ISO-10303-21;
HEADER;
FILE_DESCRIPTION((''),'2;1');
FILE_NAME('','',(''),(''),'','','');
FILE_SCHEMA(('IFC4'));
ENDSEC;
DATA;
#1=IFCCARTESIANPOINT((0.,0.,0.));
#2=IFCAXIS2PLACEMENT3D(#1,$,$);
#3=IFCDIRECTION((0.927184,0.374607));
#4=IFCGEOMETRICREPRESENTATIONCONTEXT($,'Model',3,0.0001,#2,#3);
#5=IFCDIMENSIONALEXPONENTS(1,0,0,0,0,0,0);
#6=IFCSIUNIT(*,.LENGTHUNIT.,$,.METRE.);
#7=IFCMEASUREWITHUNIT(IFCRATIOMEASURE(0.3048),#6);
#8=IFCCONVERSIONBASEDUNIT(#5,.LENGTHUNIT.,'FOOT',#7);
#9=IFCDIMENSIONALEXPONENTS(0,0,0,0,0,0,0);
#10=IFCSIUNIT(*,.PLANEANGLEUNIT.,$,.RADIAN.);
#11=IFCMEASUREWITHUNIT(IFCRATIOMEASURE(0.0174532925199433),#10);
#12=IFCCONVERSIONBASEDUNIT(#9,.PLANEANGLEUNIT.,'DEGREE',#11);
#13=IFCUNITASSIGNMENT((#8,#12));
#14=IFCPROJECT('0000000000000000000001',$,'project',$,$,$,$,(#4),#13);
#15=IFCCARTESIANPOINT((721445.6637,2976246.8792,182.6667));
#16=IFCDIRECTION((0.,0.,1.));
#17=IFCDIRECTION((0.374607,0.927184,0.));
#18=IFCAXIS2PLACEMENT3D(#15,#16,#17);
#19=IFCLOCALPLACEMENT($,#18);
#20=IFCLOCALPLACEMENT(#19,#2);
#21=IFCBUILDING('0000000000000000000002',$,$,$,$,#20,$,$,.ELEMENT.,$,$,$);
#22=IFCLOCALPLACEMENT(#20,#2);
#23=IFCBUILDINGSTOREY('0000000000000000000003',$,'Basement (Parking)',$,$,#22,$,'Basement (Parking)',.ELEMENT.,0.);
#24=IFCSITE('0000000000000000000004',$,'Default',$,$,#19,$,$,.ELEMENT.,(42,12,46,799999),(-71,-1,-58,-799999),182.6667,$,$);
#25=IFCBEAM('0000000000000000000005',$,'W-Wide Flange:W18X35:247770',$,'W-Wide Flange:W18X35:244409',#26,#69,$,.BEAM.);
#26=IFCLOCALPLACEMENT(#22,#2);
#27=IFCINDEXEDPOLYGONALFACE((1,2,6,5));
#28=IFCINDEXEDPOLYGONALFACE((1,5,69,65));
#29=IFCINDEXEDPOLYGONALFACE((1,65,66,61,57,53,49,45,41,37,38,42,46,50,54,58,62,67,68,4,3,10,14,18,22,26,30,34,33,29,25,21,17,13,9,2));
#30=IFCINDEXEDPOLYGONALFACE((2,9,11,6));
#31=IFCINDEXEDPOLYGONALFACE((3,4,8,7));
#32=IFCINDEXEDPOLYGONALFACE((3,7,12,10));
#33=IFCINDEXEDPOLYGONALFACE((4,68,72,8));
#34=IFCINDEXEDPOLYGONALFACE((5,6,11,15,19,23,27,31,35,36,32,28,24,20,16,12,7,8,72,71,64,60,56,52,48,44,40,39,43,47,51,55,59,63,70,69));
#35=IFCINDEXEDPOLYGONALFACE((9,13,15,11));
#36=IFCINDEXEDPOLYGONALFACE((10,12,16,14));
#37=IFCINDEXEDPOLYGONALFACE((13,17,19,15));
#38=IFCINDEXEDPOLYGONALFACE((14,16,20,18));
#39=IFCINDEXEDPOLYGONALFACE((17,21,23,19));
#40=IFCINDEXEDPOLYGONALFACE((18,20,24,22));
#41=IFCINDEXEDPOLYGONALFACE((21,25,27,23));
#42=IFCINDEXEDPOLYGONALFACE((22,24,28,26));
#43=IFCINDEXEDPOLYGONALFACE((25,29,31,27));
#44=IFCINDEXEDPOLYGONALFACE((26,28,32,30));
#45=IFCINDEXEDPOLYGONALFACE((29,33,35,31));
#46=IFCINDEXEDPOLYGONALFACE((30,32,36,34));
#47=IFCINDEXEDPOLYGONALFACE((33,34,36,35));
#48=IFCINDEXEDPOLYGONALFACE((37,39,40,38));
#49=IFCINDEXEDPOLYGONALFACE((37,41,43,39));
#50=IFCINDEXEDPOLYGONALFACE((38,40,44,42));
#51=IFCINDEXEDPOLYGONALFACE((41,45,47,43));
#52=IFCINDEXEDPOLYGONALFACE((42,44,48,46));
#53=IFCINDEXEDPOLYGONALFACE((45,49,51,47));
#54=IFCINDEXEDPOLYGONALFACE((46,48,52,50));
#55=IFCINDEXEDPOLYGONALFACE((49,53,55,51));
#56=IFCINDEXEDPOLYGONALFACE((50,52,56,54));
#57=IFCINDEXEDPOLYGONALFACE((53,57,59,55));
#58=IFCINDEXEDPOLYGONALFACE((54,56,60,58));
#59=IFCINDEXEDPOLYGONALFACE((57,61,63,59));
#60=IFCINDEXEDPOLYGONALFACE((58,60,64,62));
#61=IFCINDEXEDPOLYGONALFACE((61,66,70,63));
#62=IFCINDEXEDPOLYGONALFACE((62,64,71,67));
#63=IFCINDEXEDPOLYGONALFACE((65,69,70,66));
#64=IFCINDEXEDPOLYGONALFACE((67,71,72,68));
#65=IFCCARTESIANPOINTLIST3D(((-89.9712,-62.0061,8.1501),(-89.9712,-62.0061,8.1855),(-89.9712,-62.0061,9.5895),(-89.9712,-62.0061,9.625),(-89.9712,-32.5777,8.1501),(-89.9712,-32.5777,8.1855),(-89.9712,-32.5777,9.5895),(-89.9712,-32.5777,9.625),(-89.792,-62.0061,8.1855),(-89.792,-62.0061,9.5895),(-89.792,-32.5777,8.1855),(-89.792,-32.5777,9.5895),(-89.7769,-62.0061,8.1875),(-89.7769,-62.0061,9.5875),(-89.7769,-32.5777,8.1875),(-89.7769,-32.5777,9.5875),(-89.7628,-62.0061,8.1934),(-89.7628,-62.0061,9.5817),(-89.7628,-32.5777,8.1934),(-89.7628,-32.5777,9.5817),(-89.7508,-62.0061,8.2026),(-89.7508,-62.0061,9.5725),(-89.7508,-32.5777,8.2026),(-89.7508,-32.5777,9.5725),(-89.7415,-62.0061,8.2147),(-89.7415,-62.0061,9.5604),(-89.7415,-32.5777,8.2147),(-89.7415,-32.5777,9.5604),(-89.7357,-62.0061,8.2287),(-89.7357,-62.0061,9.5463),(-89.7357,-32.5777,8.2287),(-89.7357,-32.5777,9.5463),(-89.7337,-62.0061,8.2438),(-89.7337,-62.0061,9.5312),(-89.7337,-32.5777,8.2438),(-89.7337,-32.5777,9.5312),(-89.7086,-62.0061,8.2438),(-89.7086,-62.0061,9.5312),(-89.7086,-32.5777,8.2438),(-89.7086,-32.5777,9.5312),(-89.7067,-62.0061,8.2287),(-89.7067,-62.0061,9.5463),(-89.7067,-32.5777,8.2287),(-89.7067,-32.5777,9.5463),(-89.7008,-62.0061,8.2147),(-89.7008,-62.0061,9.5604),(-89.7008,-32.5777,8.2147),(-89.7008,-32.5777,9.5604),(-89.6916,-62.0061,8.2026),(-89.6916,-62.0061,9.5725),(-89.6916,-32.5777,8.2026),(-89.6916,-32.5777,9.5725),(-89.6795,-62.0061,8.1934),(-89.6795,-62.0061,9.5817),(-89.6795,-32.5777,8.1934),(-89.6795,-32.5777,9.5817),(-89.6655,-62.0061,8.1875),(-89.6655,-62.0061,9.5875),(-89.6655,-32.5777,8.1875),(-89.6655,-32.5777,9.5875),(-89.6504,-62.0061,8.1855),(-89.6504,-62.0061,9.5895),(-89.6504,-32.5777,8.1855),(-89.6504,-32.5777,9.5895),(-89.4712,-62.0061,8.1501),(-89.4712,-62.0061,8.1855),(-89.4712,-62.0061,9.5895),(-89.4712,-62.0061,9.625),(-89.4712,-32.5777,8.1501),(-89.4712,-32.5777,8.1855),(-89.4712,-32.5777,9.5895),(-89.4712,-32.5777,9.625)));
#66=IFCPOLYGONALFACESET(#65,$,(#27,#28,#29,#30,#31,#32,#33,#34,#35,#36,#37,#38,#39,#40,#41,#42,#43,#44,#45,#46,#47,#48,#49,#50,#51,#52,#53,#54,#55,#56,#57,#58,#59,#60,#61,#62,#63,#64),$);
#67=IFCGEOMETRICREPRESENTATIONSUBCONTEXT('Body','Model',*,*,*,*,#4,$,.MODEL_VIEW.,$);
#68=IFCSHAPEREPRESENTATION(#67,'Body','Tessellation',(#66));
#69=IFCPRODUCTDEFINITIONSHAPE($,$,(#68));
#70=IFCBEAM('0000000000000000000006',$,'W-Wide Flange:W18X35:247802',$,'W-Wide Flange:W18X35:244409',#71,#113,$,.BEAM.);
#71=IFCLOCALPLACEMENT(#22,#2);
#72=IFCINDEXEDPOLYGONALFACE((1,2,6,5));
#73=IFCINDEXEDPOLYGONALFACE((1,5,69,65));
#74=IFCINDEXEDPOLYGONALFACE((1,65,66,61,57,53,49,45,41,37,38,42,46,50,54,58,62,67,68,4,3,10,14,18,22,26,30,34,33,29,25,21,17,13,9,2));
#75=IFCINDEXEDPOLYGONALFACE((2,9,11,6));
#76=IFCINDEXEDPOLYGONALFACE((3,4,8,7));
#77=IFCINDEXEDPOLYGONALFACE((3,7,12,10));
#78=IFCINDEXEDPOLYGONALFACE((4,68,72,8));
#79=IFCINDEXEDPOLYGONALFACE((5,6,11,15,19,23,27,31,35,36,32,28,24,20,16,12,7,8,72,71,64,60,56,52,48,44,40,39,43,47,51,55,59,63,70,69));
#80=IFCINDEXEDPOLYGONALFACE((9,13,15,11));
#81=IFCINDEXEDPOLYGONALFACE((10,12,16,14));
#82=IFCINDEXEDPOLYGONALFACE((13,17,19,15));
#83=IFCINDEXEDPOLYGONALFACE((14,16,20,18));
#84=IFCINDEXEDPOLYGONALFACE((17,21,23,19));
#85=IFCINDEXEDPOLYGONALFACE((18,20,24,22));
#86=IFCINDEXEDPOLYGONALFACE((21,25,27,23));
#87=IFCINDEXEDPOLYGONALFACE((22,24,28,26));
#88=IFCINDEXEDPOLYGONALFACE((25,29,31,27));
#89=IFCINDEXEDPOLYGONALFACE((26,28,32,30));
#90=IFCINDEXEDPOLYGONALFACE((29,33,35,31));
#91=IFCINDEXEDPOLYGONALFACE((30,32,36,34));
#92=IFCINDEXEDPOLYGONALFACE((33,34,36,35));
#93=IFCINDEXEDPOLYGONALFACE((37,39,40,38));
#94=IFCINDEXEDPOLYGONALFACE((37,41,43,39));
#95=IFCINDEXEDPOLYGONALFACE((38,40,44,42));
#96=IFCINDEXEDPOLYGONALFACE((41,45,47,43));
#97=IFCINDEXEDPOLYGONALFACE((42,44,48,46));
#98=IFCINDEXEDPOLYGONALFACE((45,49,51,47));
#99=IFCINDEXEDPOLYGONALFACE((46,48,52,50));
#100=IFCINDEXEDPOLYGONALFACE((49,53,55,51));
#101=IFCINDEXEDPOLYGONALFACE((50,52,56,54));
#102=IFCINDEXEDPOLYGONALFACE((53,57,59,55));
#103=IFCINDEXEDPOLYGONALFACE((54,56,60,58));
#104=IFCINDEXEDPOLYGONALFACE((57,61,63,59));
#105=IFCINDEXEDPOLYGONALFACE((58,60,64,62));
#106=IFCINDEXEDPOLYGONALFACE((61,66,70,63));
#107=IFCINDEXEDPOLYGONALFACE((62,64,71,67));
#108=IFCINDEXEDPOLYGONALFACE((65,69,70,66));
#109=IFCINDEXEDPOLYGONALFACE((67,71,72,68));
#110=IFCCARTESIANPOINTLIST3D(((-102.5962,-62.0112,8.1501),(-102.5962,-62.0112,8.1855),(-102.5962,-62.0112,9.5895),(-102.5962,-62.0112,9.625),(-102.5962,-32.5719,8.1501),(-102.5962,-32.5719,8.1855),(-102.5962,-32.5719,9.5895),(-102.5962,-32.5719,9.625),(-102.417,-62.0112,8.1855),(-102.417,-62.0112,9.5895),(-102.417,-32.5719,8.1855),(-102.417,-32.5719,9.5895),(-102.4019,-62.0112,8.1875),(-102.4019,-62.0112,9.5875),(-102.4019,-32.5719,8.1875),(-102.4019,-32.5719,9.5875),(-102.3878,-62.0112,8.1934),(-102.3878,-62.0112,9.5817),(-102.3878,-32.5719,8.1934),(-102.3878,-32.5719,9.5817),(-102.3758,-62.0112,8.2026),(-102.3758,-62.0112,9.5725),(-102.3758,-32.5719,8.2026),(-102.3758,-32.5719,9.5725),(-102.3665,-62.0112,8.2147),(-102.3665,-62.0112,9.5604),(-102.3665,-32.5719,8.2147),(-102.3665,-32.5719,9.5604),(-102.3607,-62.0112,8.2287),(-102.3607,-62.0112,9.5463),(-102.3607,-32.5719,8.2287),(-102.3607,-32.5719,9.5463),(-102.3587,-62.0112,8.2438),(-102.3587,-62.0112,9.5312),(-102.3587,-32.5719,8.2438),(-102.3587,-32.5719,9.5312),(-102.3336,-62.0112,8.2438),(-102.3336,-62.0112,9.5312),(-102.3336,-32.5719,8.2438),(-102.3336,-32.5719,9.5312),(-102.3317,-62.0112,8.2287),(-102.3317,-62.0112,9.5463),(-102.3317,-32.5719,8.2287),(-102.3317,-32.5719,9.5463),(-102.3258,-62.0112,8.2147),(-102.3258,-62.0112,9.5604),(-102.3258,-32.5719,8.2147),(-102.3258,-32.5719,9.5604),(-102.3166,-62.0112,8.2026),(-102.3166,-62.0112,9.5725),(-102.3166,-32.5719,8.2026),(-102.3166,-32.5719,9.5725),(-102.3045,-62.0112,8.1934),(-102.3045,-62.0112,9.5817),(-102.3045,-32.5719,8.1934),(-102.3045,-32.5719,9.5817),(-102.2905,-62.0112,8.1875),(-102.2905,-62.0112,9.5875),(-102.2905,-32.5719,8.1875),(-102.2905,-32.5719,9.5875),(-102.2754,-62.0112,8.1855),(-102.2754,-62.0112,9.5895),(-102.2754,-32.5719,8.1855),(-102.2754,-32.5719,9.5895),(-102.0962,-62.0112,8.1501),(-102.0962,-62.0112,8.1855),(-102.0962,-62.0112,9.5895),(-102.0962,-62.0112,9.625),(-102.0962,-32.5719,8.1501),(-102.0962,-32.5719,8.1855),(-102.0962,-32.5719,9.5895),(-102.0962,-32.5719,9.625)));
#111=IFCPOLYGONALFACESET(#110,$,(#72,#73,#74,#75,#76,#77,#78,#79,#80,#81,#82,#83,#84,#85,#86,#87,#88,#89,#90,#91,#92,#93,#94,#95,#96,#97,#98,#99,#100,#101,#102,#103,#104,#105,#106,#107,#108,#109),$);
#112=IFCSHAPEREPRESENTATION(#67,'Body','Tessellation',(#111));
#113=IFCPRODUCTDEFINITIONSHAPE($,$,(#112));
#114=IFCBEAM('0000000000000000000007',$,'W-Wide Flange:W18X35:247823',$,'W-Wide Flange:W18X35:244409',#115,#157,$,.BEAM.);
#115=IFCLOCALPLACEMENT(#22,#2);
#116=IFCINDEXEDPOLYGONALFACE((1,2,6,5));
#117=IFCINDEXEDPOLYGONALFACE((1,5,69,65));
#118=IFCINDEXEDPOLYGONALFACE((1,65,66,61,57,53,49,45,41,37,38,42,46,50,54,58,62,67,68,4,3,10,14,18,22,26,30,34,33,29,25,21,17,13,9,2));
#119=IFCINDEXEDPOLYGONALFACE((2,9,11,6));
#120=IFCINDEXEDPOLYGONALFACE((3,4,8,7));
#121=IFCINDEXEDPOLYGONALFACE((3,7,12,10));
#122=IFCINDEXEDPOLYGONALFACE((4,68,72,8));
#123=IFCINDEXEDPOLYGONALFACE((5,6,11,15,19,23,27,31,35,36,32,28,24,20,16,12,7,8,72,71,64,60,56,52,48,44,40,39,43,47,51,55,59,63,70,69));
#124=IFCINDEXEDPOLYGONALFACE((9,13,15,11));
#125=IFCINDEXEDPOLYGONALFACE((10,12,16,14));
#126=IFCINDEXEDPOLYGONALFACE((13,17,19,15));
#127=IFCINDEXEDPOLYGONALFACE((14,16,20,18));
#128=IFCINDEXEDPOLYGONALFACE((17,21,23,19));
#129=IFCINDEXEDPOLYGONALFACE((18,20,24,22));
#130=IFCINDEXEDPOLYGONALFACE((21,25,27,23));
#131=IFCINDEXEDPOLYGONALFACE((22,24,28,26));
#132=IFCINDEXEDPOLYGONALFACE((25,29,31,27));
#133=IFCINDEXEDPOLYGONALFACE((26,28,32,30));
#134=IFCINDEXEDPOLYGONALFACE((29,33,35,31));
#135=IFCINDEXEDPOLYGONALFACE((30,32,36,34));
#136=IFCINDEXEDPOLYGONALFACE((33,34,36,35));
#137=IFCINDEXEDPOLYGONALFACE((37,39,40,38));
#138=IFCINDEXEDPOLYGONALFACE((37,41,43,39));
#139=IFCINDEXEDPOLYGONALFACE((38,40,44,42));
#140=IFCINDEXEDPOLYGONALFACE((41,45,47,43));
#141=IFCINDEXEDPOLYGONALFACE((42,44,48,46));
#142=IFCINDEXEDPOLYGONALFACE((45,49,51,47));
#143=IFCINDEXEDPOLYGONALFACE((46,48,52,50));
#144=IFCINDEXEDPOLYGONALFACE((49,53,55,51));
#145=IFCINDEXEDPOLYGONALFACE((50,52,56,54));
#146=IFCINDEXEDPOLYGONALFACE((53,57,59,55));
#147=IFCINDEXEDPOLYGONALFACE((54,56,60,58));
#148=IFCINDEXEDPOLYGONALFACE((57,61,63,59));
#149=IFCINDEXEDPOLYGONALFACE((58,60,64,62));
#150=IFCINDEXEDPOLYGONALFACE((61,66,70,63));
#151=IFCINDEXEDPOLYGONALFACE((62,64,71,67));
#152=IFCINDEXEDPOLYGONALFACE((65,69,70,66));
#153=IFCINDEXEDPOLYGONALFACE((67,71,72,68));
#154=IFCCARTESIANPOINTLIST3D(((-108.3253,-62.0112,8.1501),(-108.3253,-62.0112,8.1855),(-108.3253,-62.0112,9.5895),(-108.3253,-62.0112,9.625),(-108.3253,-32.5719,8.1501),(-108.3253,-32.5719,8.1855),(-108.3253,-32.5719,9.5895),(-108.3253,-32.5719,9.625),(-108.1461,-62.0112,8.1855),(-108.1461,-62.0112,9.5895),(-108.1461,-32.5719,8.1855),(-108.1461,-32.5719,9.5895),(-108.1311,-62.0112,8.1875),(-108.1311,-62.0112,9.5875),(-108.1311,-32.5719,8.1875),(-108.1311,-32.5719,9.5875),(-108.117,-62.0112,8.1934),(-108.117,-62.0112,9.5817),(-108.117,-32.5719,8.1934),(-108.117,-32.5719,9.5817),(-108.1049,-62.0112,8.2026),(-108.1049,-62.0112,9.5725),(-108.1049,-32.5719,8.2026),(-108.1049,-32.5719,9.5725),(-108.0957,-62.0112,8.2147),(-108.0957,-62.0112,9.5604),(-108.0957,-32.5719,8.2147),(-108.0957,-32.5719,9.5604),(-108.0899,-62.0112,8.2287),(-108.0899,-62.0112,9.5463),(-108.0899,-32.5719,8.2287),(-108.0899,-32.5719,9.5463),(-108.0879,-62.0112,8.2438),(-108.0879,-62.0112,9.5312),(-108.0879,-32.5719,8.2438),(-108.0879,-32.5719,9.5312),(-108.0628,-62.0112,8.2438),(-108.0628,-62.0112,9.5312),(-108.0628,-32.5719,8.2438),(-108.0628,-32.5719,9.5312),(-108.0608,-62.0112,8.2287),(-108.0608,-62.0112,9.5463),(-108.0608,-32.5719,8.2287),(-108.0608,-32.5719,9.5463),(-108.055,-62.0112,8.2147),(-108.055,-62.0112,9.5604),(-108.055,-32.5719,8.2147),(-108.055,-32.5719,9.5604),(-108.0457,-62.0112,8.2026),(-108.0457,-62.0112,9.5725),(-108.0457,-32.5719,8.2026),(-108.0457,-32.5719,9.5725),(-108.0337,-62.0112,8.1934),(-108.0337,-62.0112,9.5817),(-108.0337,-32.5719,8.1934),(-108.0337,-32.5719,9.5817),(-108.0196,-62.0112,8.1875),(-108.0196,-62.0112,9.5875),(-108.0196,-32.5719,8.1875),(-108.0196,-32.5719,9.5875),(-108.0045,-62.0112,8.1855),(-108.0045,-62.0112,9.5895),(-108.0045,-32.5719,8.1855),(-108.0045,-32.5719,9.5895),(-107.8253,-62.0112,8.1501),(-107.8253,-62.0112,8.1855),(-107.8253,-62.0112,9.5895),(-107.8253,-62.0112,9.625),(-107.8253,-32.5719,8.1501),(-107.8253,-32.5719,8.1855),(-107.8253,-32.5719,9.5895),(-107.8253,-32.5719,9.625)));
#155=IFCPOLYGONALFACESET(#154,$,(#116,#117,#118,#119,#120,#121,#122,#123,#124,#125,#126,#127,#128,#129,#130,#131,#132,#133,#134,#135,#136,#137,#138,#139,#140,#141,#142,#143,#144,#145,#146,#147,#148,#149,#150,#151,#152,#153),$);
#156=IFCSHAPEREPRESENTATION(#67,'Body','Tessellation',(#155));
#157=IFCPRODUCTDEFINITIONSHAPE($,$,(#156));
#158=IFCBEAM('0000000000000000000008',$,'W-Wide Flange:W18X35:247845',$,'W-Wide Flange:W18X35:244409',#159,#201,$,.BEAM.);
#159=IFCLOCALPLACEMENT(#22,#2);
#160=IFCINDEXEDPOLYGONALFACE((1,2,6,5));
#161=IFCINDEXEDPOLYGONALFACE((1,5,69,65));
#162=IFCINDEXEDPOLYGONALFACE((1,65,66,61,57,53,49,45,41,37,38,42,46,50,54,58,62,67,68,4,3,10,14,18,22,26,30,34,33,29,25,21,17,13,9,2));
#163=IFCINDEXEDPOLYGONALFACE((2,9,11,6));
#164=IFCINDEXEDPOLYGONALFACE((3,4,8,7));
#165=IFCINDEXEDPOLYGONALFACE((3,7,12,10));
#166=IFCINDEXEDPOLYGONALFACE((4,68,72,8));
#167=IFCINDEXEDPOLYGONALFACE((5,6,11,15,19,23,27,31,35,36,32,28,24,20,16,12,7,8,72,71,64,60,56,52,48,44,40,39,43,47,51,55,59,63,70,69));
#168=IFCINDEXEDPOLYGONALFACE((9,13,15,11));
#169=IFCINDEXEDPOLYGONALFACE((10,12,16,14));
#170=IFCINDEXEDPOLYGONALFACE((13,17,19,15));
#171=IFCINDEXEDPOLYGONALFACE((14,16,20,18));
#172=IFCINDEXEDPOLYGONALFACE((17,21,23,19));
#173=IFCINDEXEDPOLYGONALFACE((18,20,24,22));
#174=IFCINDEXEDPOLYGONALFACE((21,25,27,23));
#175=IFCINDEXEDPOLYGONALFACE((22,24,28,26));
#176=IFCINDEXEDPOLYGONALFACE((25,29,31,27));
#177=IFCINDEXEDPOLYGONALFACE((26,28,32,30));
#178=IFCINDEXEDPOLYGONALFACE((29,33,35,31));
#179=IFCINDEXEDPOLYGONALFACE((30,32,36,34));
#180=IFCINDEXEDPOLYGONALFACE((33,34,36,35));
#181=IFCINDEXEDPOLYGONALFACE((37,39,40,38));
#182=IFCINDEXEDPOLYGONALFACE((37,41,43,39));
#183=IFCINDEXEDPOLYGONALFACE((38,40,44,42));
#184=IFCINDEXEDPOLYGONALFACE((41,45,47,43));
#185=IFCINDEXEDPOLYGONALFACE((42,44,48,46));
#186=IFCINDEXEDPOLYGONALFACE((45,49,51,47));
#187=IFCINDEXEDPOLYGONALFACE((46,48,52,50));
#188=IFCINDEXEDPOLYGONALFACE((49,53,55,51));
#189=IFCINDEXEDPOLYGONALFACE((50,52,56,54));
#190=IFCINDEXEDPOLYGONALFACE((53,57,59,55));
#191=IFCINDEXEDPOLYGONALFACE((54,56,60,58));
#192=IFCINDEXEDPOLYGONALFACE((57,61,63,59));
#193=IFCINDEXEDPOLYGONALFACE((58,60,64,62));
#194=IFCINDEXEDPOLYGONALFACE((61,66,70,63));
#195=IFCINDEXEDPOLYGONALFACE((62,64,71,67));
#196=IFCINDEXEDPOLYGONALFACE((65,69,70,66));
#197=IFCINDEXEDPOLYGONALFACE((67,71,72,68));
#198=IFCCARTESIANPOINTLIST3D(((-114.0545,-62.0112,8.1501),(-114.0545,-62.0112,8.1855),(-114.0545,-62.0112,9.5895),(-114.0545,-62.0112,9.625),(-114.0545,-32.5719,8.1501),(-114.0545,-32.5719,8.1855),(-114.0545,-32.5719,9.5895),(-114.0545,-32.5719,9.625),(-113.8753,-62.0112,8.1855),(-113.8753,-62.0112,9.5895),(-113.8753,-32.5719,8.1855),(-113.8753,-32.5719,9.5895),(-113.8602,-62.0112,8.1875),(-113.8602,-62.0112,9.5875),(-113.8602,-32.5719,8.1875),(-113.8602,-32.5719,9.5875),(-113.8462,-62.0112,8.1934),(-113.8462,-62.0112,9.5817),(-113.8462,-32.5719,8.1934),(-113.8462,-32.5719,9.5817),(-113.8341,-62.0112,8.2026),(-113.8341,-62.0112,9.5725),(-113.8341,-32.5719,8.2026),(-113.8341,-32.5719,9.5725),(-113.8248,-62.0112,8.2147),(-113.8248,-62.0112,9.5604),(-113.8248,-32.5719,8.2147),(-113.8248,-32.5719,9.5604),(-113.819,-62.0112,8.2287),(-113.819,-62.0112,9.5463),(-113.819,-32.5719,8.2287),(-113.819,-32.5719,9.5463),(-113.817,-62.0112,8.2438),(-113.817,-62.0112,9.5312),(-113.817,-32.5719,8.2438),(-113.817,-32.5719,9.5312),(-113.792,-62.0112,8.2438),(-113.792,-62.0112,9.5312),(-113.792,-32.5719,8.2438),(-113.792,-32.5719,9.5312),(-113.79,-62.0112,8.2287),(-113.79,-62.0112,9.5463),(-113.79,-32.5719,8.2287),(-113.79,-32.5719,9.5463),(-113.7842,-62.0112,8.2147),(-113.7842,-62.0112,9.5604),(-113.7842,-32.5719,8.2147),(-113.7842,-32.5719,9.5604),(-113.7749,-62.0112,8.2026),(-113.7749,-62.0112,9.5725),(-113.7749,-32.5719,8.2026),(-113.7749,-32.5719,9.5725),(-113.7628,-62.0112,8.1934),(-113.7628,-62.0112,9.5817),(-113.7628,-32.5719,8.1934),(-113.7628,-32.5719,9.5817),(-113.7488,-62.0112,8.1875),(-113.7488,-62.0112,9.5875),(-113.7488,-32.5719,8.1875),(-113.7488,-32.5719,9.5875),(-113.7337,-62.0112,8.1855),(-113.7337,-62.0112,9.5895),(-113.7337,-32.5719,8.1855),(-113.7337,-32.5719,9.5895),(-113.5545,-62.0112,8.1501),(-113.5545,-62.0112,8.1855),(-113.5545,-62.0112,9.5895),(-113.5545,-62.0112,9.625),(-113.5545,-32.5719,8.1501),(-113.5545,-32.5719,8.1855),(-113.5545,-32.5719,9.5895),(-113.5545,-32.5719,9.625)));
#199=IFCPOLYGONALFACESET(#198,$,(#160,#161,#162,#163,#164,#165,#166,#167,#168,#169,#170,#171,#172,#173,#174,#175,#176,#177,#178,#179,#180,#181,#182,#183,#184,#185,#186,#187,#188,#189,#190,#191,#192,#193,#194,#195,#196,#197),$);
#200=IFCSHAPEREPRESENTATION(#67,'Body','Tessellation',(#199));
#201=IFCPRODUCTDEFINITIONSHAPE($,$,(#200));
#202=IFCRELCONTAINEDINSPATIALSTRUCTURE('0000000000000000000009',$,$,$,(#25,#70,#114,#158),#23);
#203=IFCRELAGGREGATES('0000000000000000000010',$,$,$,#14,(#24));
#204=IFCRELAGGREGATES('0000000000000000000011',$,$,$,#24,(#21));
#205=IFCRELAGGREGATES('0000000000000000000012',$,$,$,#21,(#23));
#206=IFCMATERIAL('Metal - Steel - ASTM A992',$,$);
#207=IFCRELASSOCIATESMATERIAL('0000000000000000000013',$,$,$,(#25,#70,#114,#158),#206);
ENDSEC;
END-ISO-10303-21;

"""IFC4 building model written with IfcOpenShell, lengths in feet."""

from ifc_helpers import new_model, entity, si_unit, converted_unit, direction, frame, frame_2d, origin, place, context, subcontext, project, spatial, i_section, extrude, material, element, save


model = new_model("IFC4")

# Units and contexts
model_context = context("Model", 3, precision=0.0001, world=origin(), true_north=direction((0.927184, 0.374607)))
body_context = subcontext(model_context, "Body", "Model", "MODEL_VIEW")
ifc_project = project(units=[converted_unit("LENGTHUNIT", "FOOT", entity("IfcRatioMeasure", 0.3048), si_unit("LENGTHUNIT", "METRE"), dimensions=[1, 0, 0, 0, 0, 0, 0]), converted_unit("PLANEANGLEUNIT", "DEGREE", entity("IfcRatioMeasure", 0.0174532925199433), si_unit("PLANEANGLEUNIT", "RADIAN"), dimensions=[0, 0, 0, 0, 0, 0, 0])], contexts=[model_context])

# Site, building, storey
site_placement = place(None, frame((721445.6637, 2976246.8792, 182.6667), z_axis=(0.0, 0.0, 1.0), x_axis=(0.374607, 0.927184, 0.0)))
site = spatial("IfcSite", under=ifc_project, at=site_placement, Name="Default", CompositionType="ELEMENT", RefLatitude=(42, 12, 46, 799999), RefLongitude=(-71, -1, -58, -799999), RefElevation=182.6667)
building_placement = place(site_placement, origin())
building = spatial("IfcBuilding", under=site, at=building_placement, CompositionType="ELEMENT")
storey_placement = place(building_placement, origin())
storey = spatial("IfcBuildingStorey", under=building, at=storey_placement, Name="Basement (Parking)", LongName="Basement (Parking)", CompositionType="ELEMENT", Elevation=0.0)

# Shared definitions
ifc_material_1 = material(Name="Metal - Steel - ASTM A992")

# Beams
beam_1_placement = place(storey_placement, frame((-89.7212, -62.3961, 9.625), z_axis=(0.0, 0.0, 1.0), x_axis=(0.0, 1.0, 0.0)))
element("IfcBeam", 1, at=beam_1_placement, inside=storey, material=ifc_material_1, Name="W-Wide Flange:W18X35:247770", ObjectType="W-Wide Flange:W18X35:244409", PredefinedType="BEAM", context=body_context, shape_type="SweptSolid", body=[
    extrude(i_section(OverallWidth=0.5, OverallDepth=1.4749, WebThickness=0.0251, FlangeThickness=0.0355, FilletRadius=0.0583, at=frame_2d((0.0, 0.0), x_axis=(0.0, 1.0))), frame((0.39, 0.0, -0.7375), z_axis=(1.0, 0.0, 0.0), x_axis=(0.0, 0.0, -1.0)), (0.0, 0.0, 1.0), 29.4284),
])
beam_2_placement = place(storey_placement, frame((-102.3462, -62.3961, 9.625), z_axis=(0.0, 0.0, 1.0), x_axis=(0.0, 1.0, 0.0)))
element("IfcBeam", 2, at=beam_2_placement, inside=storey, material=ifc_material_1, Name="W-Wide Flange:W18X35:247802", ObjectType="W-Wide Flange:W18X35:244409", PredefinedType="BEAM", context=body_context, shape_type="SweptSolid", body=[
    extrude(i_section(OverallWidth=0.5, OverallDepth=1.4749, WebThickness=0.0251, FlangeThickness=0.0355, FilletRadius=0.0583, at=frame_2d((0.0, 0.0), x_axis=(0.0, 1.0))), frame((0.3849, 0.0, -0.7375), z_axis=(1.0, 0.0, 0.0), x_axis=(0.0, 0.0, -1.0)), (0.0, 0.0, 1.0), 29.4393),
])
beam_3_placement = place(storey_placement, frame((-108.0753, -62.3961, 9.625), z_axis=(0.0, 0.0, 1.0), x_axis=(0.0, 1.0, 0.0)))
element("IfcBeam", 3, at=beam_3_placement, inside=storey, material=ifc_material_1, Name="W-Wide Flange:W18X35:247823", ObjectType="W-Wide Flange:W18X35:244409", PredefinedType="BEAM", context=body_context, shape_type="SweptSolid", body=[
    extrude(i_section(OverallWidth=0.5, OverallDepth=1.4749, WebThickness=0.0251, FlangeThickness=0.0355, FilletRadius=0.0583, at=frame_2d((0.0, 0.0), x_axis=(0.0, 1.0))), frame((0.3849, 0.0, -0.7375), z_axis=(1.0, 0.0, 0.0), x_axis=(0.0, 0.0, -1.0)), (0.0, 0.0, 1.0), 29.4393),
])
beam_4_placement = place(storey_placement, frame((-113.8045, -62.3961, 9.625), z_axis=(0.0, 0.0, 1.0), x_axis=(0.0, 1.0, 0.0)))
element("IfcBeam", 4, at=beam_4_placement, inside=storey, material=ifc_material_1, Name="W-Wide Flange:W18X35:247845", ObjectType="W-Wide Flange:W18X35:244409", PredefinedType="BEAM", context=body_context, shape_type="SweptSolid", body=[
    extrude(i_section(OverallWidth=0.5, OverallDepth=1.4749, WebThickness=0.0251, FlangeThickness=0.0355, FilletRadius=0.0583, at=frame_2d((0.0, 0.0), x_axis=(0.0, 1.0))), frame((0.3849, 0.0, -0.7375), z_axis=(1.0, 0.0, 0.0), x_axis=(0.0, 0.0, -1.0)), (0.0, 0.0, 1.0), 29.4393),
])

save(model, "model.ifc")
